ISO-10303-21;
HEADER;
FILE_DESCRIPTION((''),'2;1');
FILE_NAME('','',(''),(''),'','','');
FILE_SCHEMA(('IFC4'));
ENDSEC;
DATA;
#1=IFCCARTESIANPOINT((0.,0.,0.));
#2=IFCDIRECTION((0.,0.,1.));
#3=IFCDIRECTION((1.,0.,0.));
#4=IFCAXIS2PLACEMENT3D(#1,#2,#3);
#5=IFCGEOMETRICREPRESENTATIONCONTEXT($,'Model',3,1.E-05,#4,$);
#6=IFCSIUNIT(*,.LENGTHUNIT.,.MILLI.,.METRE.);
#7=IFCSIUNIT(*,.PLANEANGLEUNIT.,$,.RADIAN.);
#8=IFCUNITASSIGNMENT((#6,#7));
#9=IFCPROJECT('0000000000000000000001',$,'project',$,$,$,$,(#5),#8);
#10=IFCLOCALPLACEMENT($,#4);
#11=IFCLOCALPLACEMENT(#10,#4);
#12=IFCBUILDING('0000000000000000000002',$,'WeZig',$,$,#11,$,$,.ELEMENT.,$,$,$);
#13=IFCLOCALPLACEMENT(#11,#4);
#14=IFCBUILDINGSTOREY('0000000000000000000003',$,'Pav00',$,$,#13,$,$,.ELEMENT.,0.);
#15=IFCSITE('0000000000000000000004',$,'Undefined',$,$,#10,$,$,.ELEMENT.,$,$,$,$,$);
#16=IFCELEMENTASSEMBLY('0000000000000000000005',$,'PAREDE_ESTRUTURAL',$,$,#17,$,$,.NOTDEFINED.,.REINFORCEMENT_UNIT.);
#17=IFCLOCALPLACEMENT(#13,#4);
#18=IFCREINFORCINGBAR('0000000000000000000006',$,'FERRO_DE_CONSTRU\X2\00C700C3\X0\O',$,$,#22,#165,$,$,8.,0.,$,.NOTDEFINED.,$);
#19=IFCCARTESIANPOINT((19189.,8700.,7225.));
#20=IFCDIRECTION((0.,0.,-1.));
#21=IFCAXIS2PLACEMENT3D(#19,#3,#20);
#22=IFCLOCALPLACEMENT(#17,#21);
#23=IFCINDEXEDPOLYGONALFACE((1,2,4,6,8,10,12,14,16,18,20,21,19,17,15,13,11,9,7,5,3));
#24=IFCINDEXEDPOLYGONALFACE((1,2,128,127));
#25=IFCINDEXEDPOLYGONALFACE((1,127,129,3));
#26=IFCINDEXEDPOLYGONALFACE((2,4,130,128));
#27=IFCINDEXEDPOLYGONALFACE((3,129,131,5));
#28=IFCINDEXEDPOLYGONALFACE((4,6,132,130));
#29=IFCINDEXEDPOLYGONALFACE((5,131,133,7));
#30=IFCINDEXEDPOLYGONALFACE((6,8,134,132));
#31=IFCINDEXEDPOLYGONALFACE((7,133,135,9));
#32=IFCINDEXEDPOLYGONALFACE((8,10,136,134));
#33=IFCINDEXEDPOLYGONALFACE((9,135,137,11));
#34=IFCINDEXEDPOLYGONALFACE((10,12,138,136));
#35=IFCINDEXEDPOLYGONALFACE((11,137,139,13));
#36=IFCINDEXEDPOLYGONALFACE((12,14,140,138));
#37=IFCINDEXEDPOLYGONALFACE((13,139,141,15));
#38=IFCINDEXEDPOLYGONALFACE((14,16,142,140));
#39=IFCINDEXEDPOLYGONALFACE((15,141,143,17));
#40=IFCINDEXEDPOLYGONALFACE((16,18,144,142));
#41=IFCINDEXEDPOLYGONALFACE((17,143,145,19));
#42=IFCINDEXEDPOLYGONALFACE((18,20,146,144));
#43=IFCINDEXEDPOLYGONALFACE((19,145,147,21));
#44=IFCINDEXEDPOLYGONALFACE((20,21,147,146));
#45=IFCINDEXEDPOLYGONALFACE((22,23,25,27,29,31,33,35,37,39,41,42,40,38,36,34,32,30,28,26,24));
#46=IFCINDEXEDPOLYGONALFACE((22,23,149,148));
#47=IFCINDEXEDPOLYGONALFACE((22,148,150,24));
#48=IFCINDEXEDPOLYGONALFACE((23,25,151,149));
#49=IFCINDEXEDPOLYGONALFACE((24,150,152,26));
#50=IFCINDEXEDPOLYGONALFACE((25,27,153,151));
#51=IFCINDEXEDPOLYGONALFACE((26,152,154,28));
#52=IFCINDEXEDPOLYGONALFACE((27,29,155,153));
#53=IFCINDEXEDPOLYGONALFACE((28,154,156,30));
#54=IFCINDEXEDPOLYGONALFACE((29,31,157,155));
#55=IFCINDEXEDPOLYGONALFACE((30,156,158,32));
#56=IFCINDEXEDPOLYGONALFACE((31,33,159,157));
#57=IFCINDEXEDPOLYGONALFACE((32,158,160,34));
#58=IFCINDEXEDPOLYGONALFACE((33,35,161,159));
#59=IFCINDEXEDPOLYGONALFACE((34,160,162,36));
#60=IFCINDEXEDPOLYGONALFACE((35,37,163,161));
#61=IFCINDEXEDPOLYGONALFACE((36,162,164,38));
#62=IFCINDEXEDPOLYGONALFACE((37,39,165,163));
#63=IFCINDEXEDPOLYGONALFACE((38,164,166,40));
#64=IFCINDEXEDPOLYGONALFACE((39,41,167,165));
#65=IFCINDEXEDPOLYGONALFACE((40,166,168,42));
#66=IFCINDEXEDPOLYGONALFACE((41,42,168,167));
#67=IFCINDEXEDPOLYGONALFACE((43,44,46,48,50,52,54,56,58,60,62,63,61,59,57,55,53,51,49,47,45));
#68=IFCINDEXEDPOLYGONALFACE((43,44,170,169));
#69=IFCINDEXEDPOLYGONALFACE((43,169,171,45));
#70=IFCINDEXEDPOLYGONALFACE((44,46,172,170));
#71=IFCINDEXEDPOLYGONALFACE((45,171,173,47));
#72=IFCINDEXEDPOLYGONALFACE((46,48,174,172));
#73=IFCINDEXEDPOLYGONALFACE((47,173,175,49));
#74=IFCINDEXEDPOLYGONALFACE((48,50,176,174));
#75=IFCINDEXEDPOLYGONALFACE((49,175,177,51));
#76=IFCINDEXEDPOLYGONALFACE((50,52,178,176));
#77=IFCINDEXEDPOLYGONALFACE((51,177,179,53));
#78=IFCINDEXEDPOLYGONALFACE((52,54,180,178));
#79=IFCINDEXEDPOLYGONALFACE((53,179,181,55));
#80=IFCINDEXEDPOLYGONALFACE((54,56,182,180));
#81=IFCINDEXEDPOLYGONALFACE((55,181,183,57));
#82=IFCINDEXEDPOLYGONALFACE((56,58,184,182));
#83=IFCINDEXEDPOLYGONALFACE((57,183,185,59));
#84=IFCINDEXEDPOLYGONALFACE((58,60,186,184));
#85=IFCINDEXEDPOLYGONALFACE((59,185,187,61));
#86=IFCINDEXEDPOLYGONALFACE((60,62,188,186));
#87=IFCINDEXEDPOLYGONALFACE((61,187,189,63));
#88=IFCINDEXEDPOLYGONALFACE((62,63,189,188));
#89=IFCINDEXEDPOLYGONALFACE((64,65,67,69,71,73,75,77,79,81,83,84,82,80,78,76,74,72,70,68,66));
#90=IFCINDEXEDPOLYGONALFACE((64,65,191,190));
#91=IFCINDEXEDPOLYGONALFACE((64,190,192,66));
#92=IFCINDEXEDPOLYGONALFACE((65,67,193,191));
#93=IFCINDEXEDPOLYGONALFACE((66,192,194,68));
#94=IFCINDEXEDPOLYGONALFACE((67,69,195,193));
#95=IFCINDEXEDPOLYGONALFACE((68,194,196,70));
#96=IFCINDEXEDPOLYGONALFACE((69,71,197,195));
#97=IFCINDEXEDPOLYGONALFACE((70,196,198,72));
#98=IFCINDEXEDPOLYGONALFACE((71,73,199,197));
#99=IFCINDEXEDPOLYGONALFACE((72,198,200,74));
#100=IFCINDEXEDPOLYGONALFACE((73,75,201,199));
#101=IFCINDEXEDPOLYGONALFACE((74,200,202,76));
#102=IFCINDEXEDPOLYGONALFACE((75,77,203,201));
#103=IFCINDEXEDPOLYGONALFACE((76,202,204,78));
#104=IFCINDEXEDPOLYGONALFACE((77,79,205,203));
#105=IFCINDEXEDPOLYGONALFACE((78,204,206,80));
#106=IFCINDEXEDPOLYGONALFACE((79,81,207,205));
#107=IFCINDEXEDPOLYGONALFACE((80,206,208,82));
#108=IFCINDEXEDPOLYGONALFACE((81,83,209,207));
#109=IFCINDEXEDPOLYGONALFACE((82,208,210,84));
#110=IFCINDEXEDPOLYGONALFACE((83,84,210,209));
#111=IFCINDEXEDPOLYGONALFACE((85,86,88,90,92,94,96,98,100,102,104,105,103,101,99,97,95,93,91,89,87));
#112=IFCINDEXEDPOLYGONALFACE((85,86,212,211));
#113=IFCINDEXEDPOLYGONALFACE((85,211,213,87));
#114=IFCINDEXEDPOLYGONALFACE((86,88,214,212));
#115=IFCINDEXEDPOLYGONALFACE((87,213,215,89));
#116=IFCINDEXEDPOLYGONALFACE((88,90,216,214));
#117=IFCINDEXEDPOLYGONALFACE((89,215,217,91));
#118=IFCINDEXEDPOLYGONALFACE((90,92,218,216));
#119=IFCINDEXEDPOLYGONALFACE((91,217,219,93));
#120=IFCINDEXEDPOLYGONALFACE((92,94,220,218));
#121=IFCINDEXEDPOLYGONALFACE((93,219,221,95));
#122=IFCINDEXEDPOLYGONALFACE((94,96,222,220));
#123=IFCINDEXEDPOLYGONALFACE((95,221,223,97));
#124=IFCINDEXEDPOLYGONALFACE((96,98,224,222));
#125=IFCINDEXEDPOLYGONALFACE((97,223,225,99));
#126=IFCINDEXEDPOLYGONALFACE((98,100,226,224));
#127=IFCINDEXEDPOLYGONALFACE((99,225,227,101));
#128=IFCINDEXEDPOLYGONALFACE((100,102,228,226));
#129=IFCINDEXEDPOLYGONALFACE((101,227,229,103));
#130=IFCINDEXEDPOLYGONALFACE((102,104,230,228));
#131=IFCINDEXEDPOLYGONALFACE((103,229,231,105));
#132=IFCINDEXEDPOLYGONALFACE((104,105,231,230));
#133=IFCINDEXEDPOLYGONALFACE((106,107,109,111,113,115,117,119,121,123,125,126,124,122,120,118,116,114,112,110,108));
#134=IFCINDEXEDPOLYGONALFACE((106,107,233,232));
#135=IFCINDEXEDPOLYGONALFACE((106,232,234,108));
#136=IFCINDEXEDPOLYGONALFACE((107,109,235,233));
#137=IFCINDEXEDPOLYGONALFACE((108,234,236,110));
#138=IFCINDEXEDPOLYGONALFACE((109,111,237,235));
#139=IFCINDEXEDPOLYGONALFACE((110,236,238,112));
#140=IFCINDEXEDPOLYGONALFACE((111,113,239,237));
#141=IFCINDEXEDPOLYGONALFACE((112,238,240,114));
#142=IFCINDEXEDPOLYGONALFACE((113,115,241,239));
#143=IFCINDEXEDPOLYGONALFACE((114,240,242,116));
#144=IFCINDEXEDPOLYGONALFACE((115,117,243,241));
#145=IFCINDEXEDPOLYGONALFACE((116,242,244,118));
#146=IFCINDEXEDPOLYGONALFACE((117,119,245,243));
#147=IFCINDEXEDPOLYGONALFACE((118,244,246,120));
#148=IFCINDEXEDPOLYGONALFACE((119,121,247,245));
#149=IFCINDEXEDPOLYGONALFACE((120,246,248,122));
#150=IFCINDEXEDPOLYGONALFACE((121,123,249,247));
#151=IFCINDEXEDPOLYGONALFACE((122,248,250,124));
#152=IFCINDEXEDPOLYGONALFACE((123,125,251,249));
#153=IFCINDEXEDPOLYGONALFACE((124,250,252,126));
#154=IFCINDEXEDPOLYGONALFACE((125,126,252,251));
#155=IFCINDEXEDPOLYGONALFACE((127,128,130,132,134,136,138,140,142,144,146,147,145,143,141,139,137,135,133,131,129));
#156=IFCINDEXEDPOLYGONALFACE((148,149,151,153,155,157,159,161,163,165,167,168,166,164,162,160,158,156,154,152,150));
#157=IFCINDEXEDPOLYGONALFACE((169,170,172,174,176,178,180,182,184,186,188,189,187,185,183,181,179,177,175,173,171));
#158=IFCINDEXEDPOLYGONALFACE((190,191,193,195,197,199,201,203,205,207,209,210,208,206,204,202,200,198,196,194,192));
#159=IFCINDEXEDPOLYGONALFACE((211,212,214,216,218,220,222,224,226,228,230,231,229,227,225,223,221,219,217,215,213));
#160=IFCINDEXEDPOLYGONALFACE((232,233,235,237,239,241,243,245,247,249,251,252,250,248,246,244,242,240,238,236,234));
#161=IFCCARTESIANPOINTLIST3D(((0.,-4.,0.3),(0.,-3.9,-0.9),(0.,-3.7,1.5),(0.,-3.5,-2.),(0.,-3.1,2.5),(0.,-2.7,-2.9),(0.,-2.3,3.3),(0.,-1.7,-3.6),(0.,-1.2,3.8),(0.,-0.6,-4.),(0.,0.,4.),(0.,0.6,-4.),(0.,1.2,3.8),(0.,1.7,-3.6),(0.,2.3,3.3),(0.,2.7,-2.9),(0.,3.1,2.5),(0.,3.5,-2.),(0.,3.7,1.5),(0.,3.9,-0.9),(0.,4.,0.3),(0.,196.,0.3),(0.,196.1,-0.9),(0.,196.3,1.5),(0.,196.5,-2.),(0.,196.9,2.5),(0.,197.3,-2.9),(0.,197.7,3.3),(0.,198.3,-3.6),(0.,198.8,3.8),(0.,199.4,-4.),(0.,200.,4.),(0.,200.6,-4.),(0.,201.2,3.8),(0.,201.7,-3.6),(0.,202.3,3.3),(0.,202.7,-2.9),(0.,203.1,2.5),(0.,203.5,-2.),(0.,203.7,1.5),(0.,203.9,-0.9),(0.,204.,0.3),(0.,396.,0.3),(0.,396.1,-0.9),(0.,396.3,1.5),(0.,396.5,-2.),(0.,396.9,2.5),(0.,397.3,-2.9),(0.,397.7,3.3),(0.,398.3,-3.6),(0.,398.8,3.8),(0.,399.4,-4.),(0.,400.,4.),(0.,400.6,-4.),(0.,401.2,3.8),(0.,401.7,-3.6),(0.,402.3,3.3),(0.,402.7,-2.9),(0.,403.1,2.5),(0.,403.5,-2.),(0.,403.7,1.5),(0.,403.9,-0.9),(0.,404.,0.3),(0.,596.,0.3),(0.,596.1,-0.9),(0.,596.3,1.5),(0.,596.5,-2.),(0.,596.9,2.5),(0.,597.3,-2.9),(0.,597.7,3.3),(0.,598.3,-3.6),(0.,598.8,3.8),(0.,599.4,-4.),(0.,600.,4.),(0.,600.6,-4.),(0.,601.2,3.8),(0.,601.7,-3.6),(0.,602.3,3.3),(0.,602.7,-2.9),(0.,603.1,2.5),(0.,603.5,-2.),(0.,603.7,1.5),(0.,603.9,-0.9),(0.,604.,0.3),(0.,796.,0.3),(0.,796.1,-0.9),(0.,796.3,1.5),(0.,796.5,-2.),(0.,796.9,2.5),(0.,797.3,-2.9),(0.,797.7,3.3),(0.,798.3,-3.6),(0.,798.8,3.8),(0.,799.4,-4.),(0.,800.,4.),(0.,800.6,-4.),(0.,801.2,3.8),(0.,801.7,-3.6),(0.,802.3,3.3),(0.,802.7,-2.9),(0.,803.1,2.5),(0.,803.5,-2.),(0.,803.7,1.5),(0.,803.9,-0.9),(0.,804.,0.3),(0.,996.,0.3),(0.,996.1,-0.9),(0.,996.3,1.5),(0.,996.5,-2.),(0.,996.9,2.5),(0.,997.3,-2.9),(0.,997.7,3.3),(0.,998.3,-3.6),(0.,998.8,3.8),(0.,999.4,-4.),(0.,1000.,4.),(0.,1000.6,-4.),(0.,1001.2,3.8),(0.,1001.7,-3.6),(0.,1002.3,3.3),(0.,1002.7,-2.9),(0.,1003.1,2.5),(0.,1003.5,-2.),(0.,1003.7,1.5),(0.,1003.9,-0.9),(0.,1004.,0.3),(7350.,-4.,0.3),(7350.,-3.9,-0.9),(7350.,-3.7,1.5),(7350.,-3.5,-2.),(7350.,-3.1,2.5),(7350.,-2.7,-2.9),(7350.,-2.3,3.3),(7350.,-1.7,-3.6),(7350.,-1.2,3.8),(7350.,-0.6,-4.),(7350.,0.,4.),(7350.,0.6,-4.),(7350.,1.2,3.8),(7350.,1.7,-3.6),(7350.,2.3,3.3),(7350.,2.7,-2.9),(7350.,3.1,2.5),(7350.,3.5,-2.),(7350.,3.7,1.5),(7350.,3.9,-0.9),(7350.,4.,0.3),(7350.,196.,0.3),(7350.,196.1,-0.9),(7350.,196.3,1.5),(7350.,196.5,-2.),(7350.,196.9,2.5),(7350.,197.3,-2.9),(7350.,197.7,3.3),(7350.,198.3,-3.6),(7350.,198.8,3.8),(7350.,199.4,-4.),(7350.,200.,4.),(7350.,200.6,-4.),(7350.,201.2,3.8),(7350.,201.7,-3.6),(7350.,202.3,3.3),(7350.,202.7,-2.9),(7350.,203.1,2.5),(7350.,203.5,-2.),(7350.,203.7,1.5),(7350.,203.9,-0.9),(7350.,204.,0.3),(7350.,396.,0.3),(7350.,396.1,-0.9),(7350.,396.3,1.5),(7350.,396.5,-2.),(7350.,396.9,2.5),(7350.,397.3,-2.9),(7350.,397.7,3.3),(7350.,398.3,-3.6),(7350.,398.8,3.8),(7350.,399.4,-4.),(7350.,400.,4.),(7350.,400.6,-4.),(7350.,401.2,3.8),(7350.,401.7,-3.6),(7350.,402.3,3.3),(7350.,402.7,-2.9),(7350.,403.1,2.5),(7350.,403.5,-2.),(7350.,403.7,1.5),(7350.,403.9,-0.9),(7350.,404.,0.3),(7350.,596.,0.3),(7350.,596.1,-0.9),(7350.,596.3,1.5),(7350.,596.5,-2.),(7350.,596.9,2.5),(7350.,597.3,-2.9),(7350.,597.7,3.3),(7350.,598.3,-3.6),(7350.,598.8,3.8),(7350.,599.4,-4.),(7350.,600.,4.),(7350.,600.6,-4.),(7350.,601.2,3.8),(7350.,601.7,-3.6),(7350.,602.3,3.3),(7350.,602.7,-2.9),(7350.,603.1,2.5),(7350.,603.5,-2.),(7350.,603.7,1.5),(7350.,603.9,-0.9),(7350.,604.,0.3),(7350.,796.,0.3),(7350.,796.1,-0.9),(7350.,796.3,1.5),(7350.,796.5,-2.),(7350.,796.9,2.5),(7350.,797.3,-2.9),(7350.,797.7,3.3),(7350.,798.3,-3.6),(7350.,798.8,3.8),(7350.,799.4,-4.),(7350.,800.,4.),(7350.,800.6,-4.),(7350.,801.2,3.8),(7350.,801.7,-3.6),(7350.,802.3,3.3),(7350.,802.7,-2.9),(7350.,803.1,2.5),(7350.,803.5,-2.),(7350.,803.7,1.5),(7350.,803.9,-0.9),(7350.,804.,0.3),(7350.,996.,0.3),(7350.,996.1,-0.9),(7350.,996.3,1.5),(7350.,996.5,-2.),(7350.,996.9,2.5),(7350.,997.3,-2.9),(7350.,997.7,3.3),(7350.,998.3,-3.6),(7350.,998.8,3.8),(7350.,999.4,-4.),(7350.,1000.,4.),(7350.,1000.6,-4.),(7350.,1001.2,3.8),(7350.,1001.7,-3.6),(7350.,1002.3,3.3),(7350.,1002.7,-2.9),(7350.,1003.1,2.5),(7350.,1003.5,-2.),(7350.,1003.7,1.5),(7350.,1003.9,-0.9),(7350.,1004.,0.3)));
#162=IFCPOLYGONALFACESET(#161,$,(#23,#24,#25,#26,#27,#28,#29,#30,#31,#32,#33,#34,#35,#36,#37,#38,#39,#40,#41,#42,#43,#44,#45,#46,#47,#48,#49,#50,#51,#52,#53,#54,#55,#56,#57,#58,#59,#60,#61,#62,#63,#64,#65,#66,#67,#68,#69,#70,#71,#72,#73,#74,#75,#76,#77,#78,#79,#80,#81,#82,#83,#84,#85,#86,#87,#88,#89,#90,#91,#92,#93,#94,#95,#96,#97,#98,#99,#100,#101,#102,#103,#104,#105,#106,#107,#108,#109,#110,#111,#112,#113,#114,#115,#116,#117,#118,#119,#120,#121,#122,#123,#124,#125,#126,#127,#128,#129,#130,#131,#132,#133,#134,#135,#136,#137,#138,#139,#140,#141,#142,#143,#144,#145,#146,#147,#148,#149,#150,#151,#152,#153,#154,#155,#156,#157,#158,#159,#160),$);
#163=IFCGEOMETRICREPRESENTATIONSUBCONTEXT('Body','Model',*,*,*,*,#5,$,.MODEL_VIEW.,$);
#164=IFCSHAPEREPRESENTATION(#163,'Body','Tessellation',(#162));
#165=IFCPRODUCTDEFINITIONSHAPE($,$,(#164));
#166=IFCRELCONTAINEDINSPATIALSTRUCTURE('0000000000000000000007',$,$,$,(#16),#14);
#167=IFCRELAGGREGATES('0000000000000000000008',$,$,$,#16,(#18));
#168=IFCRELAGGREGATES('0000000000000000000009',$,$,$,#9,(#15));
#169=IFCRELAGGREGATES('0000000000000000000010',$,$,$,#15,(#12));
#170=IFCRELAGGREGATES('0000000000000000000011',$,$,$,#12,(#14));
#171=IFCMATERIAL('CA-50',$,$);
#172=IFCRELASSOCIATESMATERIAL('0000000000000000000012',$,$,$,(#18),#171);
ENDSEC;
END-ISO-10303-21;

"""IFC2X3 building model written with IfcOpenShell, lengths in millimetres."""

from ifc_helpers import new_model, entity, si_unit, frame, origin_with_axes, place, context, subcontext, project, spatial, source, transform, mapped, material, element, aggregate, save


model = new_model("IFC2X3")

# Units and contexts
model_context = context("Model", 3, precision=1e-05, world=origin_with_axes())
body_context = subcontext(model_context, "Body", "Model", "MODEL_VIEW")
ifc_project = project(units=[si_unit("LENGTHUNIT", "METRE", prefix="MILLI"), si_unit("PLANEANGLEUNIT", "RADIAN")], contexts=[model_context])

# Site, building, storey
site_placement = place(None, origin_with_axes())
site = spatial("IfcSite", under=ifc_project, at=site_placement, Name="Undefined", CompositionType="ELEMENT")
building_placement = place(site_placement, origin_with_axes())
building = spatial("IfcBuilding", under=site, at=building_placement, Name="WeZig", CompositionType="ELEMENT")
storey_placement = place(building_placement, origin_with_axes())
storey = spatial("IfcBuildingStorey", under=building, at=storey_placement, Name="Pav00", CompositionType="ELEMENT", Elevation=0.0)

# Element assembly
assembly_1_placement = place(storey_placement, origin_with_axes())
assembly_1 = element("IfcElementAssembly", 1, at=assembly_1_placement, inside=storey, Name="PAREDE_ESTRUTURAL", AssemblyPlace="NOTDEFINED", PredefinedType="REINFORCEMENT_UNIT")

# Reinforcing bar
ifc_material_1 = material(Name="CA-50")
shared_shape_1 = source(origin_with_axes(), body_context, "Body", "AdvancedSweptSolid", [
    entity("IfcSweptDiskSolid", entity("IfcTrimmedCurve", entity("IfcLine", entity("IfcCartesianPoint", [0.0, 0.0, 0.0]), entity("IfcVector", entity("IfcDirection", [1.0, 0.0, 0.0]), 1.0)), [entity("IfcParameterValue", 0.0)], [entity("IfcParameterValue", 7350.0)], True, "PARAMETER"), 4.0, None, 0.0, 7350.0),
])
shared_shape_2 = source(origin_with_axes(), body_context, "Body", "AdvancedSweptSolid", [
    entity("IfcSweptDiskSolid", entity("IfcTrimmedCurve", entity("IfcLine", entity("IfcCartesianPoint", [0.0, 0.0, 0.0]), entity("IfcVector", entity("IfcDirection", [1.0, 0.0, 0.0]), 1.0)), [entity("IfcParameterValue", 0.0)], [entity("IfcParameterValue", 7350.0)], True, "PARAMETER"), 4.0, None, 0.0, 7350.0),
])
shared_shape_3 = source(origin_with_axes(), body_context, "Body", "AdvancedSweptSolid", [
    entity("IfcSweptDiskSolid", entity("IfcTrimmedCurve", entity("IfcLine", entity("IfcCartesianPoint", [0.0, 0.0, 0.0]), entity("IfcVector", entity("IfcDirection", [1.0, 0.0, 0.0]), 1.0)), [entity("IfcParameterValue", 0.0)], [entity("IfcParameterValue", 7350.0)], True, "PARAMETER"), 4.0, None, 0.0, 7350.0),
])
shared_shape_4 = source(origin_with_axes(), body_context, "Body", "AdvancedSweptSolid", [
    entity("IfcSweptDiskSolid", entity("IfcTrimmedCurve", entity("IfcLine", entity("IfcCartesianPoint", [0.0, 0.0, 0.0]), entity("IfcVector", entity("IfcDirection", [1.0, 0.0, 0.0]), 1.0)), [entity("IfcParameterValue", 0.0)], [entity("IfcParameterValue", 7350.0)], True, "PARAMETER"), 4.0, None, 0.0, 7350.0),
])
shared_shape_5 = source(origin_with_axes(), body_context, "Body", "AdvancedSweptSolid", [
    entity("IfcSweptDiskSolid", entity("IfcTrimmedCurve", entity("IfcLine", entity("IfcCartesianPoint", [0.0, 0.0, 0.0]), entity("IfcVector", entity("IfcDirection", [1.0, 0.0, 0.0]), 1.0)), [entity("IfcParameterValue", 0.0)], [entity("IfcParameterValue", 7350.0)], True, "PARAMETER"), 4.0, None, 0.0, 7350.0),
])
shared_shape_6 = source(origin_with_axes(), body_context, "Body", "AdvancedSweptSolid", [
    entity("IfcSweptDiskSolid", entity("IfcTrimmedCurve", entity("IfcLine", entity("IfcCartesianPoint", [0.0, 0.0, 0.0]), entity("IfcVector", entity("IfcDirection", [1.0, 0.0, 0.0]), 1.0)), [entity("IfcParameterValue", 0.0)], [entity("IfcParameterValue", 7350.0)], True, "PARAMETER"), 4.0, None, 0.0, 7350.0),
])
reinforcing_bar_1_placement = place(assembly_1_placement, frame((19189.0, 8700.0, 7225.0), z_axis=(1.0, 0.0, 0.0), x_axis=(0.0, 0.0, -1.0)))
reinforcing_bar_1 = element("IfcReinforcingBar", 2, at=reinforcing_bar_1_placement, material=ifc_material_1, Name="FERRO_DE_CONSTRUÇÃO", BarRole="NOTDEFINED", CrossSectionArea=0.0, NominalDiameter=8.0, context=body_context, shape_type="MappedRepresentation", body=[
    mapped(shared_shape_1, transform((0.0, 0.0, 0.0))),
    mapped(shared_shape_2, transform((0.0, 200.0, 0.0))),
    mapped(shared_shape_3, transform((0.0, 400.0, 0.0))),
    mapped(shared_shape_4, transform((0.0, 600.0, 0.0))),
    mapped(shared_shape_5, transform((0.0, 800.0, 0.0))),
    mapped(shared_shape_6, transform((0.0, 1000.0, 0.0))),
])
aggregate(assembly_1, [reinforcing_bar_1])

save(model, "model.ifc")
